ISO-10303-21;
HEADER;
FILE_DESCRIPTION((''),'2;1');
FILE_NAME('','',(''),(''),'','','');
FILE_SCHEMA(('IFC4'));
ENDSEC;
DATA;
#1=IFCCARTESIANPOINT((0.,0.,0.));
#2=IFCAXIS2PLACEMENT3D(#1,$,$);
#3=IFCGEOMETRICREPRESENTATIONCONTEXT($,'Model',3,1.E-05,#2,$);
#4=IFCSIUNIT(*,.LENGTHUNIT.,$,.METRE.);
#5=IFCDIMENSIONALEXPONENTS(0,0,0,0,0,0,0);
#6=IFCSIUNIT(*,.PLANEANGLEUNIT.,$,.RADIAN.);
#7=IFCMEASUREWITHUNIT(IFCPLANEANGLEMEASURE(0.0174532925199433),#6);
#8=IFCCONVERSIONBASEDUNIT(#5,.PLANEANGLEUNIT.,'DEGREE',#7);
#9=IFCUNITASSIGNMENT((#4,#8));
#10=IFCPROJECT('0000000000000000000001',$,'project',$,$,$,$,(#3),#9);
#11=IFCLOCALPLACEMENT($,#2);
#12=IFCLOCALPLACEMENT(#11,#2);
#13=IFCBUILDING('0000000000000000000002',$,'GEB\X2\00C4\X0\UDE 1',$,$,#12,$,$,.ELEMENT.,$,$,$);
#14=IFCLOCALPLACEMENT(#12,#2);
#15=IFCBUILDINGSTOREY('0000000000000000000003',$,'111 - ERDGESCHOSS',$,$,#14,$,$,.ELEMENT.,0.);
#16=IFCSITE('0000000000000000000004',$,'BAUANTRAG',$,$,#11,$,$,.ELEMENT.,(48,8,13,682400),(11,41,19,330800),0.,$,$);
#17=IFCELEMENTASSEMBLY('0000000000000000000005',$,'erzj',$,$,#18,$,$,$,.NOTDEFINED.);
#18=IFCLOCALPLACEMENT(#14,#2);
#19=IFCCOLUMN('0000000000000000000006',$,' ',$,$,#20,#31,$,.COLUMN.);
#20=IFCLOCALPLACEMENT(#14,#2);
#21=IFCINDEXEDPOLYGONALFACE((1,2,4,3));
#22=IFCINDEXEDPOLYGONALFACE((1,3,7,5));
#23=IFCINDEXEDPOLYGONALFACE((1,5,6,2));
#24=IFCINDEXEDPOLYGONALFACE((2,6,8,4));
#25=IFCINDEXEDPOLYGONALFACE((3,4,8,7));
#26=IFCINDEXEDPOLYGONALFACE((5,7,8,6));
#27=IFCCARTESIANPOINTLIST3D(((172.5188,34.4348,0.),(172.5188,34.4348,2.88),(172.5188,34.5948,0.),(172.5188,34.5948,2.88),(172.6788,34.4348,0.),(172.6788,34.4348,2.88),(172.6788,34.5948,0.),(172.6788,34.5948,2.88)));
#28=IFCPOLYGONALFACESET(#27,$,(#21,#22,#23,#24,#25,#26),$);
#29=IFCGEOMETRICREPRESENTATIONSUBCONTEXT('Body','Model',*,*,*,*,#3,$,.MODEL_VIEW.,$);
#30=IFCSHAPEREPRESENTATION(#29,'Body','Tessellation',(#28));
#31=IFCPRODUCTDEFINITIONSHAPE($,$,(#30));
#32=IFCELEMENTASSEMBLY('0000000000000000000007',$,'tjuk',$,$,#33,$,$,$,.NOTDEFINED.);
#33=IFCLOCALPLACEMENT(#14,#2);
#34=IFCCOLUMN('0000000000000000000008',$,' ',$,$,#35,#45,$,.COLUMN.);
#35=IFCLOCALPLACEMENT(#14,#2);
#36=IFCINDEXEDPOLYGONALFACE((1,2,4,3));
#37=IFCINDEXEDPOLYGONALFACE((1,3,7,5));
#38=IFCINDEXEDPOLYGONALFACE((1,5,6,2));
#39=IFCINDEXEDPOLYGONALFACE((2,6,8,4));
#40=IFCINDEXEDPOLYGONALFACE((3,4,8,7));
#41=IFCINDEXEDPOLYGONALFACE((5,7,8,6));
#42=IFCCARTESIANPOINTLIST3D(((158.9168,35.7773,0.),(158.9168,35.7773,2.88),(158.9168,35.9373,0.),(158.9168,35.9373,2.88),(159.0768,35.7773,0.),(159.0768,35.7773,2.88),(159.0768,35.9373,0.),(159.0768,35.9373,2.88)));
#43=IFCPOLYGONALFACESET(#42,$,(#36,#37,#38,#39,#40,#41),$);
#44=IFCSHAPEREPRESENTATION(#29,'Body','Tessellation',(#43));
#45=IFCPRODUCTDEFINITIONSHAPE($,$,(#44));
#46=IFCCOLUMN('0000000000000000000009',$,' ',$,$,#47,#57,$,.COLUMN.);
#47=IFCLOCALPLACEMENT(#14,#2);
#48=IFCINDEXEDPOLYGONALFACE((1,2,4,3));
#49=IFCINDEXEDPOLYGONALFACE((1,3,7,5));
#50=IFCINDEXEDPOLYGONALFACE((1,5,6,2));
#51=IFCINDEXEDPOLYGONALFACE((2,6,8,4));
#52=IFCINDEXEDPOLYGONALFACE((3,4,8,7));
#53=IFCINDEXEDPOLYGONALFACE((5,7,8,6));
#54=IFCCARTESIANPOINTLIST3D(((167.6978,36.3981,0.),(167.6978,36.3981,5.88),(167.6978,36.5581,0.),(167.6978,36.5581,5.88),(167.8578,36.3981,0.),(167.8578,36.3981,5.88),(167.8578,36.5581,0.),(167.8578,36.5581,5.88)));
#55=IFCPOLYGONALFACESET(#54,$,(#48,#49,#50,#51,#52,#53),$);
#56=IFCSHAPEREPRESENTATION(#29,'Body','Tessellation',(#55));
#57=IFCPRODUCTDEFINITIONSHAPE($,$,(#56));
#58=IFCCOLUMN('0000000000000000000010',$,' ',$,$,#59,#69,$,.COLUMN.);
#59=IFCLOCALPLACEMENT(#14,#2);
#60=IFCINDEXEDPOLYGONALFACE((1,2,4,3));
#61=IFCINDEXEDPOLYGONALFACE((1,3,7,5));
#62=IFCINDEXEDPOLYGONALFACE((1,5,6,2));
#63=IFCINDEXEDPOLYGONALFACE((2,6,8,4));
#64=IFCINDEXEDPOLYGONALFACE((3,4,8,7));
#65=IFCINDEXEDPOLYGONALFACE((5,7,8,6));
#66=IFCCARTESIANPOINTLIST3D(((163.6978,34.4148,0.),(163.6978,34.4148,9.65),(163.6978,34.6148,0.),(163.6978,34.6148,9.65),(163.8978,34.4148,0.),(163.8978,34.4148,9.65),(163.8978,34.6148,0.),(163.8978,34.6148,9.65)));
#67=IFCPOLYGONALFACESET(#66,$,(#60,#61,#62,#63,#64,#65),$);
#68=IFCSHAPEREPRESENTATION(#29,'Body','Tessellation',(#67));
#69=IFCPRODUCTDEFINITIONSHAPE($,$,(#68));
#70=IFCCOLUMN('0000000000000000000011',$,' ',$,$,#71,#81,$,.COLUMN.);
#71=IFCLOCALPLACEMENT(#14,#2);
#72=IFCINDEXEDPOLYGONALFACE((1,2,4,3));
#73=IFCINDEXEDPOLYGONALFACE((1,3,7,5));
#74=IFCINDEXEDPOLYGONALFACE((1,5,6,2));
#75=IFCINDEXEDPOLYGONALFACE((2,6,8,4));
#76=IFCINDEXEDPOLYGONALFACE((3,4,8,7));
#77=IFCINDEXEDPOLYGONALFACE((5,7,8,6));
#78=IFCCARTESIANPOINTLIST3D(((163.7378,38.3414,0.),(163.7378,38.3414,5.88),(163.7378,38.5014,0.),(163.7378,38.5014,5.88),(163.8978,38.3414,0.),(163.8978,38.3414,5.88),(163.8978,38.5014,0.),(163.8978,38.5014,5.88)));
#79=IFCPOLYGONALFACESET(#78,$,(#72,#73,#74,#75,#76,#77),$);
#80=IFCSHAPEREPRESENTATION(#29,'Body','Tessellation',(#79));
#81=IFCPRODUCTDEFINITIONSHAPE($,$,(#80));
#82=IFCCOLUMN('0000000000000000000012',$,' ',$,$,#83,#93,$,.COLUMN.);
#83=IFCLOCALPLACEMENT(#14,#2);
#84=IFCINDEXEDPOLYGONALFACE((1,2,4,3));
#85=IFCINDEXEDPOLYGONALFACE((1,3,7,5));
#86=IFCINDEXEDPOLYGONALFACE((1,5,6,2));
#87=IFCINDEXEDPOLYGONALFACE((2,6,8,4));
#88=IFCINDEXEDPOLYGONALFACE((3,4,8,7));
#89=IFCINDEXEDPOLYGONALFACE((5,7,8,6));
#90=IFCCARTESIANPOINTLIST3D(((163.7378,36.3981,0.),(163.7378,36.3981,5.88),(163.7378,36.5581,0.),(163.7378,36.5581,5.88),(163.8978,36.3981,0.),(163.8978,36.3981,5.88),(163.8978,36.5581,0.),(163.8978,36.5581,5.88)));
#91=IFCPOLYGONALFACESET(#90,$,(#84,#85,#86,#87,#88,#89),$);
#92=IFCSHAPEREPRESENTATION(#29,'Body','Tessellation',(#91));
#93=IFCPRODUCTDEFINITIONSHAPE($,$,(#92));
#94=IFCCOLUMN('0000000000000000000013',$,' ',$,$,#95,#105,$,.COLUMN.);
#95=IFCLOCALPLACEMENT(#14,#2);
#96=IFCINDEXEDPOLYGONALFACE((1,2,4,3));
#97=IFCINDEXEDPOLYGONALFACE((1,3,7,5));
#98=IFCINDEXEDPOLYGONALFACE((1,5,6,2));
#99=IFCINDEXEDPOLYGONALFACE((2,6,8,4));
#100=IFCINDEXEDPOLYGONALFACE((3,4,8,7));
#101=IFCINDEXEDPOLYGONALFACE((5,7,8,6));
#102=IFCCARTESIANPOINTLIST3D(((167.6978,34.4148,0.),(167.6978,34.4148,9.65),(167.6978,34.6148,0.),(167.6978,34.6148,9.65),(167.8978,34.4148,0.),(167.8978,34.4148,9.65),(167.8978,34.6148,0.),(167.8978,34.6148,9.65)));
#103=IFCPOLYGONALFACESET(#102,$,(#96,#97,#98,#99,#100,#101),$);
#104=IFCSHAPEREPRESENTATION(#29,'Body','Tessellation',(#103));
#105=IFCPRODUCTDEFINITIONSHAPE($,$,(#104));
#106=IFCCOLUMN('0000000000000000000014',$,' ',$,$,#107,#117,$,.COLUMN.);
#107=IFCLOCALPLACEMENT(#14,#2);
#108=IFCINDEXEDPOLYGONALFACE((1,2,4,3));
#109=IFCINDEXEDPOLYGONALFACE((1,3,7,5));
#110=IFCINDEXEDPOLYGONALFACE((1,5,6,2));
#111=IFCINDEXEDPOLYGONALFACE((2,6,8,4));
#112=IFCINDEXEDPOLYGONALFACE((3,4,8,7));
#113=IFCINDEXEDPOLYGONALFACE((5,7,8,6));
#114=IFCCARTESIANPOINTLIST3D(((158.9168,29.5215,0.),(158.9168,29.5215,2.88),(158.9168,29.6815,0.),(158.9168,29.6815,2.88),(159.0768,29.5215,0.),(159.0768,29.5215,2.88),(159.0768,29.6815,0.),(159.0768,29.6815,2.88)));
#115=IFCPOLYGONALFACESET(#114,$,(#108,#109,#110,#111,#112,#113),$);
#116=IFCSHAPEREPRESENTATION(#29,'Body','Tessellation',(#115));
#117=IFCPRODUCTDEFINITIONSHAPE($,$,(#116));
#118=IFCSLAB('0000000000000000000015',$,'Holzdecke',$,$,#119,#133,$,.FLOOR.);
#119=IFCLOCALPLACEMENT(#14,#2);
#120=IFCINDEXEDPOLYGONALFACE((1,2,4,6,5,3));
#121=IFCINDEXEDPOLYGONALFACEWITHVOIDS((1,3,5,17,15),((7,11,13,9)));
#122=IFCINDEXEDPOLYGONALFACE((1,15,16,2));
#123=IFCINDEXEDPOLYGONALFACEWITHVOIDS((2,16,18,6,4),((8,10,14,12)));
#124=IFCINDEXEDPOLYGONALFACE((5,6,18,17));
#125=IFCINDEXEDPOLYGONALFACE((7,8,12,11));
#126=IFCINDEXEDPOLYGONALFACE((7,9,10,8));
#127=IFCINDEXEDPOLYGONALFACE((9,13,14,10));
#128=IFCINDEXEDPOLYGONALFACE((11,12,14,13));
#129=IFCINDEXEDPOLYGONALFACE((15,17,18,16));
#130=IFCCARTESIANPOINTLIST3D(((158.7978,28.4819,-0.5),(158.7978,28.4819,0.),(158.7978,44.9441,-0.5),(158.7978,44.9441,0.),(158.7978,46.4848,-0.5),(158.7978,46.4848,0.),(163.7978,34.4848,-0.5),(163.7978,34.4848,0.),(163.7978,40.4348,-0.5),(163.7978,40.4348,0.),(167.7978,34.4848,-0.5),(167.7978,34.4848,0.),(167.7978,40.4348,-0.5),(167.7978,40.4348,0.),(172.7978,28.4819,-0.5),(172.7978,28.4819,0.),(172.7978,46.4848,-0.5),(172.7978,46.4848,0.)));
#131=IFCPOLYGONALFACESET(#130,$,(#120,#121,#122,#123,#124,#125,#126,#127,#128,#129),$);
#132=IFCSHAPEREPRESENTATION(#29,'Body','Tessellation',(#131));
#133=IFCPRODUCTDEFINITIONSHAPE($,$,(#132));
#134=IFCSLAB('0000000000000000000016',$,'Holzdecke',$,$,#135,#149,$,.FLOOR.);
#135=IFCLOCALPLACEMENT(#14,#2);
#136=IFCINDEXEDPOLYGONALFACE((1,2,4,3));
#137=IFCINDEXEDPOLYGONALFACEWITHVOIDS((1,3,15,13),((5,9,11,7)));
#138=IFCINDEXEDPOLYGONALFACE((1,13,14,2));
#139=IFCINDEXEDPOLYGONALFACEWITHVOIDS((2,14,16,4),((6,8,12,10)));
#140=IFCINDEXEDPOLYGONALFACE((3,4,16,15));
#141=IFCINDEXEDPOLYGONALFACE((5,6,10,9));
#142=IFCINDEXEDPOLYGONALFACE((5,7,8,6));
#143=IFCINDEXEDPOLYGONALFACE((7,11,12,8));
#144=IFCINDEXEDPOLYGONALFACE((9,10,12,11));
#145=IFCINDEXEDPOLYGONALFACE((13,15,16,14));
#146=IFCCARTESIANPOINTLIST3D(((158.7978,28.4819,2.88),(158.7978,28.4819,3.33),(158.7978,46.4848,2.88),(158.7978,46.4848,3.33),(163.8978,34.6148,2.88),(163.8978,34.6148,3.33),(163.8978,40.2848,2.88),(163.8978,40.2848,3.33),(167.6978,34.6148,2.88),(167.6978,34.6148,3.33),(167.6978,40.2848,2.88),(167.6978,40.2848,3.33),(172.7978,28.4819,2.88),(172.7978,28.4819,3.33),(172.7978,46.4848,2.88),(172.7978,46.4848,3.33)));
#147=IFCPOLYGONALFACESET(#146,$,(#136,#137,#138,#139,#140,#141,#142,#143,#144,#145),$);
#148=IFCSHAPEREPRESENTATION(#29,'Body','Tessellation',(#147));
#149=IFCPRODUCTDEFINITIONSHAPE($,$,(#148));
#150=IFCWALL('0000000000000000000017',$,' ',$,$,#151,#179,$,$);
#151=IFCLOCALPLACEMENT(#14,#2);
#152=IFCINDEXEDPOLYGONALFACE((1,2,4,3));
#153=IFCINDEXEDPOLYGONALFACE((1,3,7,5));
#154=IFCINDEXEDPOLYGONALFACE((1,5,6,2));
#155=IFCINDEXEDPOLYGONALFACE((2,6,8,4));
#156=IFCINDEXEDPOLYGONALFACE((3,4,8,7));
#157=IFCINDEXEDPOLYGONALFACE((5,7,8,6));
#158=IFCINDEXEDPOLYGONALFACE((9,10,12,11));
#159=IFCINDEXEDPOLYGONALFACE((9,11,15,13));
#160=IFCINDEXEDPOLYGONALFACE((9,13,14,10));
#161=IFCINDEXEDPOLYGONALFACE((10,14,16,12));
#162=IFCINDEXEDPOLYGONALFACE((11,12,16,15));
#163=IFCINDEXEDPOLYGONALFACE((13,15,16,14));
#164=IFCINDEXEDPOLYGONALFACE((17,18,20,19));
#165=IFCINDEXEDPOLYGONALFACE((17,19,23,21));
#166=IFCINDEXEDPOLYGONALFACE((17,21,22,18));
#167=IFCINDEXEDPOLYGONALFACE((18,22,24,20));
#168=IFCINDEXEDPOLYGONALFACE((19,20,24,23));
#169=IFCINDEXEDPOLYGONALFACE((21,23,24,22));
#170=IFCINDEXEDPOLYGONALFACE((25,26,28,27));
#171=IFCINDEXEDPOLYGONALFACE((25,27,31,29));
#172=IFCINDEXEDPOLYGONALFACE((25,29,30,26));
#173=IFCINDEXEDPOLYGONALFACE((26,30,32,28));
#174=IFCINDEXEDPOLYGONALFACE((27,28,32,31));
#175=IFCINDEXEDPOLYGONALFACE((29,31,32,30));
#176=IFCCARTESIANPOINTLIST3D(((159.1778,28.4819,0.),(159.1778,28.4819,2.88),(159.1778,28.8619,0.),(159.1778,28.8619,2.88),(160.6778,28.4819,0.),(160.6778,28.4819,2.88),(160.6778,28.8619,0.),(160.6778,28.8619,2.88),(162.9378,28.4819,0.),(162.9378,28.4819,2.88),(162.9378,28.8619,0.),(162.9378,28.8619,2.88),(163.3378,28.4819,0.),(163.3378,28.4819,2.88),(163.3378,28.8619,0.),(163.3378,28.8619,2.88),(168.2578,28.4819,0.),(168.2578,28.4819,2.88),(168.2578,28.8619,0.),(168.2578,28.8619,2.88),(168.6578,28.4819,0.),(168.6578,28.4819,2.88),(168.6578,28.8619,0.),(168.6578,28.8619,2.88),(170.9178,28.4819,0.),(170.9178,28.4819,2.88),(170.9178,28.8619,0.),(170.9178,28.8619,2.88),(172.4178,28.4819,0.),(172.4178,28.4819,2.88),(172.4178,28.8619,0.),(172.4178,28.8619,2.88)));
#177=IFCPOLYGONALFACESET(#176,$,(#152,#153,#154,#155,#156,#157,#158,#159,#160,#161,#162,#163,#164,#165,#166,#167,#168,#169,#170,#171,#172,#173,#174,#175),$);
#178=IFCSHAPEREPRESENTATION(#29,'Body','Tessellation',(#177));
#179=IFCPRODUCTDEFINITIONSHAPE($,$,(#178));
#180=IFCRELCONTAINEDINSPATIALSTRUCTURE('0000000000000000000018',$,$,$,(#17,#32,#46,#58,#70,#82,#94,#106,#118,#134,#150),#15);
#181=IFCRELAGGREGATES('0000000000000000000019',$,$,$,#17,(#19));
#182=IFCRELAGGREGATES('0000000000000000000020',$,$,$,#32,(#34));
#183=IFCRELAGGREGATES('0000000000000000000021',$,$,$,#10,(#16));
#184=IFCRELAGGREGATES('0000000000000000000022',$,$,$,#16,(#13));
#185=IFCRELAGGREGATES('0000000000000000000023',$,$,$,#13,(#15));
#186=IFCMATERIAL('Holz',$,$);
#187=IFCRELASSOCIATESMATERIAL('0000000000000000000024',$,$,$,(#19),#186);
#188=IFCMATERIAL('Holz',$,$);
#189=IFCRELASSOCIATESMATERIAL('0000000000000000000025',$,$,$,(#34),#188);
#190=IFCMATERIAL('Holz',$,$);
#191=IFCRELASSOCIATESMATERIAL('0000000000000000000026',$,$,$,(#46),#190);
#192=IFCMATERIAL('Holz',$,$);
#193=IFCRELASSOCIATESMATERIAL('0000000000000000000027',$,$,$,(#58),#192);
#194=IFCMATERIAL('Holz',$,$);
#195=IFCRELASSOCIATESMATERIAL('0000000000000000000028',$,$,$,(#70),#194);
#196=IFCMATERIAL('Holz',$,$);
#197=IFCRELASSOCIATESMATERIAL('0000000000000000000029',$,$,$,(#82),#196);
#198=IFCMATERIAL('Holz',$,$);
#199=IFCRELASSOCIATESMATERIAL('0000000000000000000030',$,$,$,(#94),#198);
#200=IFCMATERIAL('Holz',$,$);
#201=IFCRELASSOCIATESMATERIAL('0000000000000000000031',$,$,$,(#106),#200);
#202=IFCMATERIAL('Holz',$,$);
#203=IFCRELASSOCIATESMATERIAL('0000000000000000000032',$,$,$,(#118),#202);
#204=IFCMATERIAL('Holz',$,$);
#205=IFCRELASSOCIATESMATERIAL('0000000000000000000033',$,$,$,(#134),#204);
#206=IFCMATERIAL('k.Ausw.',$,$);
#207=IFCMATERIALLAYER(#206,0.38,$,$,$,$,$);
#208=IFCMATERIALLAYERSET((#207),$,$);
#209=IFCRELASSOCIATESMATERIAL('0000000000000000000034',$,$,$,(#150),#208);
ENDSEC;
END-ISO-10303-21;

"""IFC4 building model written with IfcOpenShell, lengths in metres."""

from ifc_helpers import new_model, entity, si_unit, converted_unit, frame, frame_2d, origin, origin_with_axes, place, context, subcontext, project, spatial, polyline, rectangle, outline, extrude, material, layer, layer_set, layer_usage, element, aggregate, save


model = new_model("IFC4")

# Units and contexts
model_context = context("Model", 3, precision=1e-05, world=origin())
body_context = subcontext(model_context, "Body", "Model", "MODEL_VIEW")
ifc_project = project(units=[si_unit("LENGTHUNIT", "METRE"), converted_unit("PLANEANGLEUNIT", "DEGREE", entity("IfcPlaneAngleMeasure", 0.0174532925199433), si_unit("PLANEANGLEUNIT", "RADIAN"), dimensions=[0, 0, 0, 0, 0, 0, 0])], contexts=[model_context])

# Site, building, storey
site_placement = place(None, origin())
site = spatial("IfcSite", under=ifc_project, at=site_placement, Name="BAUANTRAG", CompositionType="ELEMENT", RefLatitude=(48, 8, 13, 682400), RefLongitude=(11, 41, 19, 330800), RefElevation=0.0)
building_placement = place(site_placement, origin())
building = spatial("IfcBuilding", under=site, at=building_placement, Name="GEBÄUDE 1", CompositionType="ELEMENT")
storey_placement = place(building_placement, origin())
storey = spatial("IfcBuildingStorey", under=building, at=storey_placement, Name="111 - ERDGESCHOSS", CompositionType="ELEMENT", Elevation=0.0)

# Element assemblies, columns
assembly_1_placement = place(storey_placement, origin())
assembly_1 = element("IfcElementAssembly", 1, at=assembly_1_placement, inside=storey, Name="erzj", PredefinedType="NOTDEFINED")
ifc_material_1 = material(Name="Holz")
column_1_placement = place(assembly_1_placement, frame((172.5188, 34.4348, 0.0)))
column_1 = element("IfcColumn", 2, at=column_1_placement, material=ifc_material_1, Name=" ", PredefinedType="COLUMN", context=body_context, shape_type="SweptSolid", body=[
    extrude(rectangle(XDim=0.16, YDim=0.16, at=frame_2d((0.08, 0.08), x_axis=(1.0, 0.0))), origin_with_axes(), (0.0, 0.0, 1.0), 2.88),
])
aggregate(assembly_1, [column_1])
assembly_2_placement = place(storey_placement, origin())
assembly_2 = element("IfcElementAssembly", 3, at=assembly_2_placement, inside=storey, Name="tjuk", PredefinedType="NOTDEFINED")
ifc_material_2 = material(Name="Holz")
column_2_placement = place(assembly_2_placement, frame((158.9168, 35.7773, 0.0)))
column_2 = element("IfcColumn", 4, at=column_2_placement, material=ifc_material_2, Name=" ", PredefinedType="COLUMN", context=body_context, shape_type="SweptSolid", body=[
    extrude(rectangle(XDim=0.16, YDim=0.16, at=frame_2d((0.08, 0.08), x_axis=(1.0, 0.0))), origin_with_axes(), (0.0, 0.0, 1.0), 2.88),
])
aggregate(assembly_2, [column_2])

# Columns
ifc_material_3 = material(Name="Holz")
column_3_placement = place(storey_placement, frame((167.6978, 36.3981, 0.0)))
element("IfcColumn", 5, at=column_3_placement, inside=storey, material=ifc_material_3, Name=" ", PredefinedType="COLUMN", context=body_context, shape_type="SweptSolid", body=[
    extrude(rectangle(XDim=0.16, YDim=0.16, at=frame_2d((0.08, 0.08), x_axis=(1.0, 0.0))), origin_with_axes(), (0.0, 0.0, 1.0), 5.88),
])
ifc_material_4 = material(Name="Holz")
column_4_placement = place(storey_placement, frame((163.6978, 34.4148, 0.0)))
element("IfcColumn", 6, at=column_4_placement, inside=storey, material=ifc_material_4, Name=" ", PredefinedType="COLUMN", context=body_context, shape_type="SweptSolid", body=[
    extrude(rectangle(XDim=0.2, YDim=0.2, at=frame_2d((0.1, 0.1), x_axis=(1.0, 0.0))), origin_with_axes(), (0.0, 0.0, 1.0), 9.65),
])
ifc_material_5 = material(Name="Holz")
column_5_placement = place(storey_placement, frame((163.7378, 38.3414, 0.0)))
element("IfcColumn", 7, at=column_5_placement, inside=storey, material=ifc_material_5, Name=" ", PredefinedType="COLUMN", context=body_context, shape_type="SweptSolid", body=[
    extrude(rectangle(XDim=0.16, YDim=0.16, at=frame_2d((0.08, 0.08), x_axis=(1.0, 0.0))), origin_with_axes(), (0.0, 0.0, 1.0), 5.88),
])
ifc_material_6 = material(Name="Holz")
column_6_placement = place(storey_placement, frame((163.7378, 36.3981, 0.0)))
element("IfcColumn", 8, at=column_6_placement, inside=storey, material=ifc_material_6, Name=" ", PredefinedType="COLUMN", context=body_context, shape_type="SweptSolid", body=[
    extrude(rectangle(XDim=0.16, YDim=0.16, at=frame_2d((0.08, 0.08), x_axis=(1.0, 0.0))), origin_with_axes(), (0.0, 0.0, 1.0), 5.88),
])
ifc_material_7 = material(Name="Holz")
column_7_placement = place(storey_placement, frame((167.6978, 34.4148, 0.0)))
element("IfcColumn", 9, at=column_7_placement, inside=storey, material=ifc_material_7, Name=" ", PredefinedType="COLUMN", context=body_context, shape_type="SweptSolid", body=[
    extrude(rectangle(XDim=0.2, YDim=0.2, at=frame_2d((0.1, 0.1), x_axis=(1.0, 0.0))), origin_with_axes(), (0.0, 0.0, 1.0), 9.65),
])
ifc_material_8 = material(Name="Holz")
column_8_placement = place(storey_placement, frame((158.9168, 29.5215, 0.0)))
element("IfcColumn", 10, at=column_8_placement, inside=storey, material=ifc_material_8, Name=" ", PredefinedType="COLUMN", context=body_context, shape_type="SweptSolid", body=[
    extrude(rectangle(XDim=0.16, YDim=0.16, at=frame_2d((0.08, 0.08), x_axis=(1.0, 0.0))), origin_with_axes(), (0.0, 0.0, 1.0), 2.88),
])

# Slab
ifc_material_9 = material(Name="Holz")
slab_1_placement = place(storey_placement, frame((158.7978, 28.4819, -0.5)))
element("IfcSlab", 11, at=slab_1_placement, inside=storey, material=ifc_material_9, Name="Holzdecke", PredefinedType="FLOOR", context=body_context, shape_type="SweptSolid", body=[
    extrude(outline(polyline([(0.0, 16.4622), (0.0, 0.0), (14.0, 0.0), (14.0, 18.0029), (0.0, 18.0029), (0.0, 16.4622)]), holes=[polyline([(5.0, 11.9529), (9.0, 11.9529), (9.0, 6.0029), (5.0, 6.0029), (5.0, 11.9529)])]), origin_with_axes(), (0.0, 0.0, 1.0), 0.5),
])

# Slab, opening
ifc_material_10 = material(Name="Holz")
slab_2_placement = place(storey_placement, frame((158.7978, 28.4819, 2.88)))
slab_2 = element("IfcSlab", 12, at=slab_2_placement, inside=storey, material=ifc_material_10, Name="Holzdecke", PredefinedType="FLOOR", context=body_context, shape_type="SweptSolid", body=[
    extrude(rectangle(XDim=18.0029, YDim=14.0, at=frame_2d((-7.0, 9.0014), x_axis=(0.0, 1.0))), frame((14.0, 0.0, 0.0), z_axis=(0.0, 0.0, 1.0), x_axis=(1.0, 0.0, 0.0)), (0.0, 0.0, 1.0), 0.45),
])
opening_1_placement = place(slab_2_placement, frame((5.1, 6.1329, 0.0)))
element("IfcOpeningElement", 13, at=opening_1_placement, cuts=slab_2, ObjectType="Opening", context=body_context, shape_type="SweptSolid", body=[
    extrude(rectangle(XDim=5.67, YDim=3.8, at=frame_2d((0.0, 0.0), x_axis=(0.0, -1.0))), frame((1.9, 2.835, 0.0), z_axis=(0.0, 0.0, 1.0), x_axis=(1.0, 0.0, 0.0)), (0.0, 0.0, 1.0), 0.45),
])

# Wall, openings
ifc_material_11 = material(Name="k.Ausw.")
ifc_layer_1 = layer(ifc_material_11, 0.38)
ifc_layer_set_1 = layer_set([ifc_layer_1])
ifc_layer_usage_1 = layer_usage(ifc_layer_set_1, "AXIS2", "POSITIVE", 0.0)
wall_1_placement = place(storey_placement, frame((159.1778, 28.4819, 0.0)))
wall_1 = element("IfcWall", 14, at=wall_1_placement, inside=storey, material=ifc_layer_usage_1, Name=" ", context=body_context, shape_type="SweptSolid", body=[
    extrude(rectangle(XDim=13.24, YDim=0.38, at=frame_2d((6.62, 0.19), x_axis=(1.0, 0.0))), origin_with_axes(), (0.0, 0.0, 1.0), 2.88),
])
opening_2_placement = place(wall_1_placement, frame((9.48, 0.0, 0.0), z_axis=(0.0, 1.0, 0.0), x_axis=(0.0, 0.0, 1.0)))
element("IfcOpeningElement", 15, at=opening_2_placement, cuts=wall_1, ObjectType="Opening", context=body_context, shape_type="SweptSolid", body=[
    extrude(outline(polyline([(0.0, 2.26), (2.88, 2.26), (2.88, 0.0), (0.0, 0.0), (0.0, 2.26)])), origin_with_axes(), (0.0, 0.0, 1.0), 0.38),
])
opening_3_placement = place(wall_1_placement, frame((1.5, 0.0, 0.0), z_axis=(0.0, 1.0, 0.0), x_axis=(0.0, 0.0, 1.0)))
element("IfcOpeningElement", 16, at=opening_3_placement, cuts=wall_1, ObjectType="Opening", context=body_context, shape_type="SweptSolid", body=[
    extrude(outline(polyline([(0.0, 2.26), (2.88, 2.26), (2.88, 0.0), (0.0, 0.0), (0.0, 2.26)])), origin_with_axes(), (0.0, 0.0, 1.0), 0.38),
])
opening_4_placement = place(wall_1_placement, frame((4.16, 0.0, 0.0), z_axis=(0.0, 1.0, 0.0), x_axis=(0.0, 0.0, 1.0)))
element("IfcOpeningElement", 17, at=opening_4_placement, cuts=wall_1, ObjectType="Opening", context=body_context, shape_type="SweptSolid", body=[
    extrude(outline(polyline([(0.0, 4.92), (2.88, 4.92), (2.88, 0.0), (0.0, 0.0), (0.0, 4.92)])), origin_with_axes(), (0.0, 0.0, 1.0), 0.38),
])

save(model, "model.ifc")
